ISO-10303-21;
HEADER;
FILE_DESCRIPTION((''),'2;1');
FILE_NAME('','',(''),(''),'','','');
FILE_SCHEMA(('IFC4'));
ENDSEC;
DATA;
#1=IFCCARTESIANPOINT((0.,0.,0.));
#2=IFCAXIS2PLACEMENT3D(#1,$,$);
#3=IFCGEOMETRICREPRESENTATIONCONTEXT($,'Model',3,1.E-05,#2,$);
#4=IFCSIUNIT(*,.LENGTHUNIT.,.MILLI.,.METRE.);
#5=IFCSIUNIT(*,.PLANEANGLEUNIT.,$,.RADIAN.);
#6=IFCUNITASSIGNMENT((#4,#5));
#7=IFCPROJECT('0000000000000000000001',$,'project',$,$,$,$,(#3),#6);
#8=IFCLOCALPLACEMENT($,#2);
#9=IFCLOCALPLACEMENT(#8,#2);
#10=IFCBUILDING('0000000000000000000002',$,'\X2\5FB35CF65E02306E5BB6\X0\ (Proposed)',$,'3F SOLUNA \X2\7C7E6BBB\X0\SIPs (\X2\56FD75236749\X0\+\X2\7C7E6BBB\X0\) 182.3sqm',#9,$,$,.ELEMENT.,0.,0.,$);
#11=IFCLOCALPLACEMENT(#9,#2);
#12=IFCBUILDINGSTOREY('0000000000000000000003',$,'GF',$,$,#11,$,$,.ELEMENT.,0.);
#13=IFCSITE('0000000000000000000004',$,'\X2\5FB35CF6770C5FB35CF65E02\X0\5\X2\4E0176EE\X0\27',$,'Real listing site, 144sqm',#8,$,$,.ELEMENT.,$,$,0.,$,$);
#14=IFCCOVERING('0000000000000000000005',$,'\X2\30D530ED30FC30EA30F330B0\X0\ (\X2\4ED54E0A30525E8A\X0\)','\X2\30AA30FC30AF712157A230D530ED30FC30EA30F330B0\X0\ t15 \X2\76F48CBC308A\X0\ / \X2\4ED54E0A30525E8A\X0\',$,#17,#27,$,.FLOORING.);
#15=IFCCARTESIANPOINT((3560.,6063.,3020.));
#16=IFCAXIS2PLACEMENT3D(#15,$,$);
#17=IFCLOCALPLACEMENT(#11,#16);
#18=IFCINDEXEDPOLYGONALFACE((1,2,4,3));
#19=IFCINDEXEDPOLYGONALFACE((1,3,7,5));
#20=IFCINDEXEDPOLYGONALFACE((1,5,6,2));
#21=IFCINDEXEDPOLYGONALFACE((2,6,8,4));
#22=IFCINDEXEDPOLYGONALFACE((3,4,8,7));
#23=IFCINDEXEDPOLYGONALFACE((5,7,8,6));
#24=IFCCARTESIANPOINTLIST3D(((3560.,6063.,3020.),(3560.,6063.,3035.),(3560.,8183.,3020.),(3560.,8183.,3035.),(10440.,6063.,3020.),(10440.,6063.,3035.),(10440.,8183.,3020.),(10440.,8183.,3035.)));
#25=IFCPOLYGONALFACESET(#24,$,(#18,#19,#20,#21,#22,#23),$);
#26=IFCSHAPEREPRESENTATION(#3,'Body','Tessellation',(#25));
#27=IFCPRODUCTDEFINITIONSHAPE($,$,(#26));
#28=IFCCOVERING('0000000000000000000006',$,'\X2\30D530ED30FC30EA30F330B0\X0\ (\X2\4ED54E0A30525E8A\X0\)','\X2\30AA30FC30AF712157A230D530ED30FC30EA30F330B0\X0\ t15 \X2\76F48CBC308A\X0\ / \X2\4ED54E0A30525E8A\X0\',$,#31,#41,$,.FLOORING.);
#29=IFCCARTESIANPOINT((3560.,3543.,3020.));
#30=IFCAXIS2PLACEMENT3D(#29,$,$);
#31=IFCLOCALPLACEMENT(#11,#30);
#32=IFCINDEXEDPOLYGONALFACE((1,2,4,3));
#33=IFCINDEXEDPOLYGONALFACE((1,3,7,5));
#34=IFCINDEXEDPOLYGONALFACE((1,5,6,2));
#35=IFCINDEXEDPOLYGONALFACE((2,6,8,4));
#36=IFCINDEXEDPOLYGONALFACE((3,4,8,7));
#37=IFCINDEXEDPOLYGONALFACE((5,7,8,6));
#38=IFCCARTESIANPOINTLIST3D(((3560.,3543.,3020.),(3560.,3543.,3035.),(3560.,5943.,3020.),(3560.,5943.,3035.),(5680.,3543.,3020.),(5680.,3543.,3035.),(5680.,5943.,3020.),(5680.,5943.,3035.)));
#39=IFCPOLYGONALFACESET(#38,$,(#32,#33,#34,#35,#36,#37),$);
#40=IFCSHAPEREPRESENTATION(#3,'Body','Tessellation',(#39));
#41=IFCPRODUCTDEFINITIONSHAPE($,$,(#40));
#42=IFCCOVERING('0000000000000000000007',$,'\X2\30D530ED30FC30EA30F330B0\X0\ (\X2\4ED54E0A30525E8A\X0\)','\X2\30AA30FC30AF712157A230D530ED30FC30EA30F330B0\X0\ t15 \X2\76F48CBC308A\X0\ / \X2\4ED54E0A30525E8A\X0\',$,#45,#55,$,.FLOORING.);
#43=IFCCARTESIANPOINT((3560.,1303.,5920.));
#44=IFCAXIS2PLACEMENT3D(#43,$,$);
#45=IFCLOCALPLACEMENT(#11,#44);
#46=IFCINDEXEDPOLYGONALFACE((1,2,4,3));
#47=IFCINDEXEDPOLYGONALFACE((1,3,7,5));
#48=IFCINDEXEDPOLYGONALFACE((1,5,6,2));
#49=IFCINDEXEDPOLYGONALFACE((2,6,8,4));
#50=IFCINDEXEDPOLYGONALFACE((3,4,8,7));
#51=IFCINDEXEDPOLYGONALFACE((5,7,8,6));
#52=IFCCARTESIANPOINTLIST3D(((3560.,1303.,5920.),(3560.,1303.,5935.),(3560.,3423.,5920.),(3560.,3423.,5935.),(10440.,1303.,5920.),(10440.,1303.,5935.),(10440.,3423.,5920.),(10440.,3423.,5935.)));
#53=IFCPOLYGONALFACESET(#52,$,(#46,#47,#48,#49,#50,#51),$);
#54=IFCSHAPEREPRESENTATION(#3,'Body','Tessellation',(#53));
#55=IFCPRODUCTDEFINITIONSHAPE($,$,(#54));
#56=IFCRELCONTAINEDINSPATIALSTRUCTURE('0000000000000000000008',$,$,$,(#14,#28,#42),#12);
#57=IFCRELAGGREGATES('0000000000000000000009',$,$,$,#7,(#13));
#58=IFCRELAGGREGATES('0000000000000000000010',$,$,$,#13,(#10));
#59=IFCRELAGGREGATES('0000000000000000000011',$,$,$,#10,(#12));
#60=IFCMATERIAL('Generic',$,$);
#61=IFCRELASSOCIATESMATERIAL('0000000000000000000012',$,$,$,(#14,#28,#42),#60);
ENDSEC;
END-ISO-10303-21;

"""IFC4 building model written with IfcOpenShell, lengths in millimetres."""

from ifc_helpers import new_model, si_unit, frame, frame_2d, origin, place, context, project, spatial, rectangle, extrude, material, element, save


model = new_model("IFC4")

# Units and contexts
model_context = context("Model", 3, precision=1e-05, world=origin())
ifc_project = project(units=[si_unit("LENGTHUNIT", "METRE", prefix="MILLI"), si_unit("PLANEANGLEUNIT", "RADIAN")], contexts=[model_context])

# Site, building, storey
site_placement = place(None, origin())
site = spatial("IfcSite", under=ifc_project, at=site_placement, Name="徳島県徳島市5丁目27", ObjectType="Real listing site, 144sqm", CompositionType="ELEMENT", RefElevation=0.0)
building_placement = place(site_placement, origin())
building = spatial("IfcBuilding", under=site, at=building_placement, Name="徳島市の家 (Proposed)", ObjectType="3F SOLUNA 籾殻SIPs (国産杉+籾殻) 182.3sqm", CompositionType="ELEMENT", ElevationOfRefHeight=0.0, ElevationOfTerrain=0.0)
storey_placement = place(building_placement, origin())
storey = spatial("IfcBuildingStorey", under=building, at=storey_placement, Name="GF", CompositionType="ELEMENT", Elevation=0.0)

# Shared definitions
ifc_material_1 = material(Name="Generic")

# Coverings
covering_1_placement = place(storey_placement, frame((3560.0, 6063.0, 3020.0)))
element("IfcCovering", 1, at=covering_1_placement, inside=storey, material=ifc_material_1, Name="フローリング (仕上げ床)", Description="オーク無垢フローリング t15 直貼り / 仕上げ床", PredefinedType="FLOORING", context=model_context, shape_type="SweptSolid", body=[
    extrude(rectangle(XDim=6880.0, YDim=2120.0, at=frame_2d((3440.0, 1060.0))), frame((3560.0, 6063.0, 3020.0)), (0.0, 0.0, 1.0), 15.0),
])
covering_2_placement = place(storey_placement, frame((3560.0, 3543.0, 3020.0)))
element("IfcCovering", 2, at=covering_2_placement, inside=storey, material=ifc_material_1, Name="フローリング (仕上げ床)", Description="オーク無垢フローリング t15 直貼り / 仕上げ床", PredefinedType="FLOORING", context=model_context, shape_type="SweptSolid", body=[
    extrude(rectangle(XDim=2120.0, YDim=2400.0, at=frame_2d((1060.0, 1200.0))), frame((3560.0, 3543.0, 3020.0)), (0.0, 0.0, 1.0), 15.0),
])
covering_3_placement = place(storey_placement, frame((3560.0, 1303.0, 5920.0)))
element("IfcCovering", 3, at=covering_3_placement, inside=storey, material=ifc_material_1, Name="フローリング (仕上げ床)", Description="オーク無垢フローリング t15 直貼り / 仕上げ床", PredefinedType="FLOORING", context=model_context, shape_type="SweptSolid", body=[
    extrude(rectangle(XDim=6880.0, YDim=2120.0, at=frame_2d((3440.0, 1060.0))), frame((3560.0, 1303.0, 5920.0)), (0.0, 0.0, 1.0), 15.0),
])

save(model, "model.ifc")
